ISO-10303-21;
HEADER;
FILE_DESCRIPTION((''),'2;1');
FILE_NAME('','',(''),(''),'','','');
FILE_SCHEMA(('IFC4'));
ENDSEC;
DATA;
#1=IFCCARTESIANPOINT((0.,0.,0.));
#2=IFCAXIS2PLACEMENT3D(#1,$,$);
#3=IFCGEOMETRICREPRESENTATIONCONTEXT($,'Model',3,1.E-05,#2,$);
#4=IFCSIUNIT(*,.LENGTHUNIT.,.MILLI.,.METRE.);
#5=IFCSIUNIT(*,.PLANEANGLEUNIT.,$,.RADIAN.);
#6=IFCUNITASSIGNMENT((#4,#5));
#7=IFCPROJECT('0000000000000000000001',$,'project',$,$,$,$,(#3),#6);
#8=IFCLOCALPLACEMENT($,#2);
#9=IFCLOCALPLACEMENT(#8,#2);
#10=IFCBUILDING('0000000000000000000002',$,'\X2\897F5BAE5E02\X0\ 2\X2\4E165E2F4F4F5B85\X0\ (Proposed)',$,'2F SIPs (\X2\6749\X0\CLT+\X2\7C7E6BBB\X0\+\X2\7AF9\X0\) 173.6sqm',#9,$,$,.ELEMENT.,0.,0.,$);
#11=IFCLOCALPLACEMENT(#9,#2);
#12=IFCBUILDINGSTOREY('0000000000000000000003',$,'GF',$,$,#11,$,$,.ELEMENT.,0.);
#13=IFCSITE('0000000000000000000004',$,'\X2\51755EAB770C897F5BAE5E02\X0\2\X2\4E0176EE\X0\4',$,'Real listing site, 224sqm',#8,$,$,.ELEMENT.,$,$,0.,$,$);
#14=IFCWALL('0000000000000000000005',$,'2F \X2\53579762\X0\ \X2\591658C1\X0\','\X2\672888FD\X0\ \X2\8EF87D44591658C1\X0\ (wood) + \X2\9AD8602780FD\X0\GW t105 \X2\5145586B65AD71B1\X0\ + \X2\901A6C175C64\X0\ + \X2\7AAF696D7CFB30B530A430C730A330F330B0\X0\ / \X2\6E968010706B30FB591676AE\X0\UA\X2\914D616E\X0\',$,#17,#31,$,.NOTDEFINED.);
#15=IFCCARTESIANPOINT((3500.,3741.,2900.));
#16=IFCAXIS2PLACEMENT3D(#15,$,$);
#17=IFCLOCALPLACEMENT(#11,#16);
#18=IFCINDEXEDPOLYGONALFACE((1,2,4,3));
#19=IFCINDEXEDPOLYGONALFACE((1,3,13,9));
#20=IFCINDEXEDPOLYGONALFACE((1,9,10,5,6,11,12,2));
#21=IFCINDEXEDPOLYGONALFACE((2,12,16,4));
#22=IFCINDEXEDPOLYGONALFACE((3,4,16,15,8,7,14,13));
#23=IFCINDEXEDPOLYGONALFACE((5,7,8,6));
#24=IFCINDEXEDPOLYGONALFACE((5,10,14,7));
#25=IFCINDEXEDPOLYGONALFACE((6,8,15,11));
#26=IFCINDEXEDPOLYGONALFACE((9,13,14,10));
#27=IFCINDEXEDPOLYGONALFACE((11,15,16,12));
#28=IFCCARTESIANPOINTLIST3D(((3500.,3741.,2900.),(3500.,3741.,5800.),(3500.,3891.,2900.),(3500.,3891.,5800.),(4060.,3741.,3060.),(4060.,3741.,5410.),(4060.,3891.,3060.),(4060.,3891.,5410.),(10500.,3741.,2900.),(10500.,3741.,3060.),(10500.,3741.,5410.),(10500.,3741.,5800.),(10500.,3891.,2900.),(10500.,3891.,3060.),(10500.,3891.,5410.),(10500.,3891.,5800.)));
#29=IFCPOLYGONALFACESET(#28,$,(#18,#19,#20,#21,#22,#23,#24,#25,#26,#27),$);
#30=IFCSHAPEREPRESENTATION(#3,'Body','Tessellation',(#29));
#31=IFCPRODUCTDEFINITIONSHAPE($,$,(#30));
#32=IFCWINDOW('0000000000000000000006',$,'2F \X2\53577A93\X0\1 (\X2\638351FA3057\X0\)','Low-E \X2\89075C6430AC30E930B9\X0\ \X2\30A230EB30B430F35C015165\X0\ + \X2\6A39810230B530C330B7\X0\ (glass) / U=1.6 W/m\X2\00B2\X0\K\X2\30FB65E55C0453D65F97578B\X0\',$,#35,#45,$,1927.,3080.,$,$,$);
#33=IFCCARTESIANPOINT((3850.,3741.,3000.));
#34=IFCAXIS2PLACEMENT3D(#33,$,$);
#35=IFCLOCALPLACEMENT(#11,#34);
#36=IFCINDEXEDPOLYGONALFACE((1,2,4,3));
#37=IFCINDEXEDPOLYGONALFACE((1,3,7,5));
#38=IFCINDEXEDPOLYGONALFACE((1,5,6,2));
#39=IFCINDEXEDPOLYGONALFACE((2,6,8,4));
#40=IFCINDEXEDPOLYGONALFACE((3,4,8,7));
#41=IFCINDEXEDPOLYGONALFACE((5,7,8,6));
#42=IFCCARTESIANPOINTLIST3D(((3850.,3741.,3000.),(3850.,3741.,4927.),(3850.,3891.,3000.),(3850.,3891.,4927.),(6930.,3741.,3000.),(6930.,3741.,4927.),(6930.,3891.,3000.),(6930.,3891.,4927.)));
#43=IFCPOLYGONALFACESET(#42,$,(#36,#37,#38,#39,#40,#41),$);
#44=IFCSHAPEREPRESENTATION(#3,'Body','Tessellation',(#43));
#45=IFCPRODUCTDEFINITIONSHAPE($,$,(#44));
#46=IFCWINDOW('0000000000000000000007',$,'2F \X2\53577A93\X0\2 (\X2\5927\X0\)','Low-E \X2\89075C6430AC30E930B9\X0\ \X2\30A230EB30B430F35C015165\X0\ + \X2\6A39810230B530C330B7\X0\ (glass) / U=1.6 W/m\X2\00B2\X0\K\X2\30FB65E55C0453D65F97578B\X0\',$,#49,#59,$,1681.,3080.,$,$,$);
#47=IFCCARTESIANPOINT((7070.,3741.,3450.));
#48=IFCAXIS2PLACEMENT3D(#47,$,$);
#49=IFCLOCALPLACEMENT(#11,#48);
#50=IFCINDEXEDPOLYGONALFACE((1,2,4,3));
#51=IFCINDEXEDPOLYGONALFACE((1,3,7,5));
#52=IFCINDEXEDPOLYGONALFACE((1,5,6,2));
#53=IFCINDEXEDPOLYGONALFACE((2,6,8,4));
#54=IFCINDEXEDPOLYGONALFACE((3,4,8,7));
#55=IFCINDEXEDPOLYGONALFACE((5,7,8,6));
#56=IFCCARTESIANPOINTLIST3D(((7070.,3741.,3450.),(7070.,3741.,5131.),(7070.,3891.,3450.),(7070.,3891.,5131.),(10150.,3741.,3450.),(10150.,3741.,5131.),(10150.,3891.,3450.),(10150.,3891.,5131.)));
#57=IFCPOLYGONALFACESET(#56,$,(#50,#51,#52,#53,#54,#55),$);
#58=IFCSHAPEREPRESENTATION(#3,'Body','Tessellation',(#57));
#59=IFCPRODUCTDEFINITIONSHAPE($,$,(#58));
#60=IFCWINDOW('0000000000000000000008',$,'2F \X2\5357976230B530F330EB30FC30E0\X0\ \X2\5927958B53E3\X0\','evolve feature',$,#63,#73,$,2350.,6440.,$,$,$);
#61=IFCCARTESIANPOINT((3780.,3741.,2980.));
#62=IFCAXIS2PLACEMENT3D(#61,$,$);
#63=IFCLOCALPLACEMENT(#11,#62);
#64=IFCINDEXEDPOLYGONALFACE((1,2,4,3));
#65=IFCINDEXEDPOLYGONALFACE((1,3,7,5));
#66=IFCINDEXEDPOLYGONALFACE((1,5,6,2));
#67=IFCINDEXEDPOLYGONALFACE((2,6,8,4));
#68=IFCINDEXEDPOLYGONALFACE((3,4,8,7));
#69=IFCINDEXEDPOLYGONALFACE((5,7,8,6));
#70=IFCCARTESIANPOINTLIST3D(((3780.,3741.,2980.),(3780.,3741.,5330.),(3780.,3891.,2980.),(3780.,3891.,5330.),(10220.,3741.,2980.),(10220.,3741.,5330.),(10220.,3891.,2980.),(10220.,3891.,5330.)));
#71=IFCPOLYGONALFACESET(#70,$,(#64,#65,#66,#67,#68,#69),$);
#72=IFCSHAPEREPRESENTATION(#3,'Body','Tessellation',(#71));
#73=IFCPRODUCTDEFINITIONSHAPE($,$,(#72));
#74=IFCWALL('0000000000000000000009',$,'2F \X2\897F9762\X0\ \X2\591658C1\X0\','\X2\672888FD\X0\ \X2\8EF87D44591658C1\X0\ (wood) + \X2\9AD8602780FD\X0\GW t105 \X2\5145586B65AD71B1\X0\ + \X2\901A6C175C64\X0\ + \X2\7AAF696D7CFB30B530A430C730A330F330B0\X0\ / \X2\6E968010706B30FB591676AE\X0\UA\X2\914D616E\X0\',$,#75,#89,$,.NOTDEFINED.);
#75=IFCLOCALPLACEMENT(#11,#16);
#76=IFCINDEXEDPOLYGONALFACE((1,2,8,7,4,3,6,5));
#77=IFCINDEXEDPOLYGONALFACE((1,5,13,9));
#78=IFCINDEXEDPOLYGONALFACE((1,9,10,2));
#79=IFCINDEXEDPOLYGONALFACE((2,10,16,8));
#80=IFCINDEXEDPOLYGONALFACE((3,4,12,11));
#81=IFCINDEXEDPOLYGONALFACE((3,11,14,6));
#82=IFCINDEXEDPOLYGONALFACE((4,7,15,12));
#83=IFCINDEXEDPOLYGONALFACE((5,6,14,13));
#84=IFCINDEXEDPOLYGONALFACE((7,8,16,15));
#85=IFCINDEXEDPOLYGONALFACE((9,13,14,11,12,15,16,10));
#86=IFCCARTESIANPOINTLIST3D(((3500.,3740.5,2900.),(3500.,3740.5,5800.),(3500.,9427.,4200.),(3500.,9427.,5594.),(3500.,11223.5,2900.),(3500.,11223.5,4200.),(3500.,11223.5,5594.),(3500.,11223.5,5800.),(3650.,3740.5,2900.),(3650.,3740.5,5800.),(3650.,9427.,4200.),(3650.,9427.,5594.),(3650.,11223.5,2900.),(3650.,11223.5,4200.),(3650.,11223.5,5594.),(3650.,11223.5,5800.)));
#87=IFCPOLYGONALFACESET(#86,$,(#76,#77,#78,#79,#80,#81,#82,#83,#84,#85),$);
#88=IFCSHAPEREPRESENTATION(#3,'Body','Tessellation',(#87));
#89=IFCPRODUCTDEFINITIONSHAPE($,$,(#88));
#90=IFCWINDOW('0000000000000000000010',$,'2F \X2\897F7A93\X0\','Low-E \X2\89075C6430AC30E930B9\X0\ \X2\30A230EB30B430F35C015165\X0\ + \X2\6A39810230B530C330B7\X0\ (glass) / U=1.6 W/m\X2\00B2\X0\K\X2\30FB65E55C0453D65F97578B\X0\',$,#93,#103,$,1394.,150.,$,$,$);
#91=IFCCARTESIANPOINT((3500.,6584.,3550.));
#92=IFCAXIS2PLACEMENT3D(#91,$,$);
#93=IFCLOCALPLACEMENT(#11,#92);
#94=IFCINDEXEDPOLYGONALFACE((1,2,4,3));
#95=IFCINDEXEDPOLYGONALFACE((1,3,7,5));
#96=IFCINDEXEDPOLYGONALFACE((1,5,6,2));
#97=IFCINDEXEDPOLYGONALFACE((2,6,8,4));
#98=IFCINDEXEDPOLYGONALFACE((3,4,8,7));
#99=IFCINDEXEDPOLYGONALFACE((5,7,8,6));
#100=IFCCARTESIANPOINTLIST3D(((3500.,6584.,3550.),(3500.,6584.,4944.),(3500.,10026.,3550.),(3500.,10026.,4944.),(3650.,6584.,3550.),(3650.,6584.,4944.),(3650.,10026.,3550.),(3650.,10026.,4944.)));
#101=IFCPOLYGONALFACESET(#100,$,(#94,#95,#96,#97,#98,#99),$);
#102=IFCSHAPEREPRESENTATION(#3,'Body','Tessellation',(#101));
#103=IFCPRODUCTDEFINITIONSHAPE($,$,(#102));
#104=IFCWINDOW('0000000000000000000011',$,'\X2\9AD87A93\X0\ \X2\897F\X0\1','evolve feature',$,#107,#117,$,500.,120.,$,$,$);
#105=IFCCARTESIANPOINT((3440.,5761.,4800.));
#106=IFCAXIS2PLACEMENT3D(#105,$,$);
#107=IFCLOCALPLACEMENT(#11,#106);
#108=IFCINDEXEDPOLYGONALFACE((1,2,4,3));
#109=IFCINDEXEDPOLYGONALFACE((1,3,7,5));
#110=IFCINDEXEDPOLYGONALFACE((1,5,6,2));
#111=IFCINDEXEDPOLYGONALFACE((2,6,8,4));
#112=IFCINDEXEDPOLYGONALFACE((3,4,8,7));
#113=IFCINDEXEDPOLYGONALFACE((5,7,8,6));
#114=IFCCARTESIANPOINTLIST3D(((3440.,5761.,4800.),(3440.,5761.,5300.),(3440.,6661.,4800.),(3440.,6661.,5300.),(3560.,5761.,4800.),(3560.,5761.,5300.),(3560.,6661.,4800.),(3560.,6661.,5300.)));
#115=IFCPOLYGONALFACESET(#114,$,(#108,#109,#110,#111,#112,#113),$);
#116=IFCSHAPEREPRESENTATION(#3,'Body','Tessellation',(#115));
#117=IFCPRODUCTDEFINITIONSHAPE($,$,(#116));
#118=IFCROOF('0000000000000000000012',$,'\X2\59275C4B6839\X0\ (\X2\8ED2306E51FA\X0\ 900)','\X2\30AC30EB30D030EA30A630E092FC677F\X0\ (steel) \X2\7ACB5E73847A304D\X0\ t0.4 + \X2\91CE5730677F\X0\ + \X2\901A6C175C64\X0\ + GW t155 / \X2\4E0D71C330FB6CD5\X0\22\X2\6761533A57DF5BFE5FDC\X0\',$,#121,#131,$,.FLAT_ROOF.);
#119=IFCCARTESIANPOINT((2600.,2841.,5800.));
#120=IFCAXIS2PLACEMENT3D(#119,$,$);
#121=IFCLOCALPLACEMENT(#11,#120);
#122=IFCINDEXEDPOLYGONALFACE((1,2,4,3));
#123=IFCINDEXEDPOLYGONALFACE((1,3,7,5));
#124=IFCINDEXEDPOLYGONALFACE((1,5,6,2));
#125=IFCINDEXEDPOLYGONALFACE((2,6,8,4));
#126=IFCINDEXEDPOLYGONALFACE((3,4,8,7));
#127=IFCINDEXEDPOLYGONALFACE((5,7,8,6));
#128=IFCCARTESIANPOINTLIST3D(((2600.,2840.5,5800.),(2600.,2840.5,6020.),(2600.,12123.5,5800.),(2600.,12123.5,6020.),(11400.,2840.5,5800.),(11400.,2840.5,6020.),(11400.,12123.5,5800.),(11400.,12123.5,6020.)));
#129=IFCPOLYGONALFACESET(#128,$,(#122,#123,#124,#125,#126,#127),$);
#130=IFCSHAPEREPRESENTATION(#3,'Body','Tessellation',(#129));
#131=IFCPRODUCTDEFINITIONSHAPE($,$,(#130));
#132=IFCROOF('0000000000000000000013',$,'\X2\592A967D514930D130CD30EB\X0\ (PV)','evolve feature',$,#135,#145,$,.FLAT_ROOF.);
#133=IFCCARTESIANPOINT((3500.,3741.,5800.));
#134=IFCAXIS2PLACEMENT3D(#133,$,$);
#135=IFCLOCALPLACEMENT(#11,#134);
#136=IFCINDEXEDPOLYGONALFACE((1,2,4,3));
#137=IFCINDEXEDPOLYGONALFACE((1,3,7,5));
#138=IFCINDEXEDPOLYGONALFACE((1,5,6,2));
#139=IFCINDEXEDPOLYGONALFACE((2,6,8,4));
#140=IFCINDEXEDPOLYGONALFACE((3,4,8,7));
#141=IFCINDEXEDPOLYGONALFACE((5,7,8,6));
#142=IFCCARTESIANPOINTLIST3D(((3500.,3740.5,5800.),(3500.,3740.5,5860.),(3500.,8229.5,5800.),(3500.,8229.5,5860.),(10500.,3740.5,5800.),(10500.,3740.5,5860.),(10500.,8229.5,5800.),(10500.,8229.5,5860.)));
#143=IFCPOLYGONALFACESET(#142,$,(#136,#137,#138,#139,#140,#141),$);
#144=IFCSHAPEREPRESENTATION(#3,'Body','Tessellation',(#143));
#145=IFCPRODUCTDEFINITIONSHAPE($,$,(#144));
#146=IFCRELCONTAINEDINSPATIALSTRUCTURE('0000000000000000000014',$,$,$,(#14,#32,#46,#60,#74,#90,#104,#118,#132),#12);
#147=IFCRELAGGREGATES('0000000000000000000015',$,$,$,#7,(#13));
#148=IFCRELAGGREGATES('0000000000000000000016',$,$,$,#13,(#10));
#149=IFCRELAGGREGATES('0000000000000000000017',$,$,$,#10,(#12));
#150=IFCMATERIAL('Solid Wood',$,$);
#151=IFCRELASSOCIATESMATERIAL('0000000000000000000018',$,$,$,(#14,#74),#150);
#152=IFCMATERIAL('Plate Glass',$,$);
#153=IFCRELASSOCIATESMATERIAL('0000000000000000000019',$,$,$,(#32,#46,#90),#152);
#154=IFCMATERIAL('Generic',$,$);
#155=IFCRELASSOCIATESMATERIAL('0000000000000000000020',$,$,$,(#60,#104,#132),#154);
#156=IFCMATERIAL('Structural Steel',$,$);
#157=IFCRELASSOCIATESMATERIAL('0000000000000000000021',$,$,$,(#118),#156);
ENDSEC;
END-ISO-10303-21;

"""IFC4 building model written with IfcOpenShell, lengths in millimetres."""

from ifc_helpers import new_model, si_unit, frame, frame_2d, origin, place, context, project, spatial, rectangle, extrude, material, element, fill, save


model = new_model("IFC4")

# Units and contexts
model_context = context("Model", 3, precision=1e-05, world=origin())
ifc_project = project(units=[si_unit("LENGTHUNIT", "METRE", prefix="MILLI"), si_unit("PLANEANGLEUNIT", "RADIAN")], contexts=[model_context])

# Site, building, storey
site_placement = place(None, origin())
site = spatial("IfcSite", under=ifc_project, at=site_placement, Name="兵庫県西宮市2丁目4", ObjectType="Real listing site, 224sqm", CompositionType="ELEMENT", RefElevation=0.0)
building_placement = place(site_placement, origin())
building = spatial("IfcBuilding", under=site, at=building_placement, Name="西宮市 2世帯住宅 (Proposed)", ObjectType="2F SIPs (杉CLT+籾殻+竹) 173.6sqm", CompositionType="ELEMENT", ElevationOfRefHeight=0.0, ElevationOfTerrain=0.0)
storey_placement = place(building_placement, origin())
storey = spatial("IfcBuildingStorey", under=building, at=storey_placement, Name="GF", CompositionType="ELEMENT", Elevation=0.0)

# Shared definitions
ifc_material_1 = material(Name="Solid Wood")
ifc_material_2 = material(Name="Generic")

# Shared definitions
ifc_material_3 = material(Name="Plate Glass")

# Walls, openings, windows
wall_1_placement = place(storey_placement, frame((3500.0, 3741.0, 2900.0)))
wall_1 = element("IfcWall", 1, at=wall_1_placement, inside=storey, material=ifc_material_1, Name="2F 南面 外壁", Description="木製 軸組外壁 (wood) + 高性能GW t105 充填断熱 + 通気層 + 窯業系サイディング / 準耐火・外皮UA配慮", PredefinedType="NOTDEFINED", context=model_context, shape_type="SweptSolid", body=[
    extrude(rectangle(XDim=7000.0, YDim=150.0, at=frame_2d((3500.0, 75.0))), frame((3500.0, 3741.0, 2900.0)), (0.0, 0.0, 1.0), 2900.0),
])
opening_1_placement = place(storey_placement, frame((3850.0, 3741.0, 3000.0)))
opening_1 = element("IfcOpeningElement", 2, at=opening_1_placement, cuts=wall_1, PredefinedType="NOTDEFINED", context=model_context, shape_type="SweptSolid", body=[
    extrude(rectangle(XDim=3080.0, YDim=150.0, at=frame_2d((1540.0, 75.0))), frame((3850.0, 3741.0, 3000.0)), (0.0, 0.0, 1.0), 1927.0),
])
opening_2_placement = place(storey_placement, frame((7070.0, 3741.0, 3450.0)))
opening_2 = element("IfcOpeningElement", 3, at=opening_2_placement, cuts=wall_1, PredefinedType="NOTDEFINED", context=model_context, shape_type="SweptSolid", body=[
    extrude(rectangle(XDim=3080.0, YDim=150.0, at=frame_2d((1540.0, 75.0))), frame((7070.0, 3741.0, 3450.0)), (0.0, 0.0, 1.0), 1681.0),
])
opening_3_placement = place(storey_placement, frame((3780.0, 3741.0, 2980.0)))
opening_3 = element("IfcOpeningElement", 4, at=opening_3_placement, cuts=wall_1, PredefinedType="NOTDEFINED", context=model_context, shape_type="SweptSolid", body=[
    extrude(rectangle(XDim=6440.0, YDim=150.0, at=frame_2d((3220.0, 75.0))), frame((3780.0, 3741.0, 2980.0)), (0.0, 0.0, 1.0), 2350.0),
])
window_1_placement = place(storey_placement, frame((3850.0, 3741.0, 3000.0)))
window_1 = element("IfcWindow", 5, at=window_1_placement, inside=storey, material=ifc_material_3, Name="2F 南窓1 (掃出し)", Description="Low-E 複層ガラス アルゴン封入 + 樹脂サッシ (glass) / U=1.6 W/m²K・日射取得型", OverallHeight=1927.0, OverallWidth=3080.0, context=model_context, shape_type="SweptSolid", body=[
    extrude(rectangle(XDim=3080.0, YDim=150.0, at=frame_2d((1540.0, 75.0))), frame((3850.0, 3741.0, 3000.0)), (0.0, 0.0, 1.0), 1927.0),
])
fill(opening_1, window_1)
window_2_placement = place(storey_placement, frame((7070.0, 3741.0, 3450.0)))
window_2 = element("IfcWindow", 6, at=window_2_placement, inside=storey, material=ifc_material_3, Name="2F 南窓2 (大)", Description="Low-E 複層ガラス アルゴン封入 + 樹脂サッシ (glass) / U=1.6 W/m²K・日射取得型", OverallHeight=1681.0, OverallWidth=3080.0, context=model_context, shape_type="SweptSolid", body=[
    extrude(rectangle(XDim=3080.0, YDim=150.0, at=frame_2d((1540.0, 75.0))), frame((7070.0, 3741.0, 3450.0)), (0.0, 0.0, 1.0), 1681.0),
])
fill(opening_2, window_2)
window_3_placement = place(storey_placement, frame((3780.0, 3741.0, 2980.0)))
window_3 = element("IfcWindow", 7, at=window_3_placement, inside=storey, material=ifc_material_2, Name="2F 南面サンルーム 大開口", Description="evolve feature", OverallHeight=2350.0, OverallWidth=6440.0, context=model_context, shape_type="SweptSolid", body=[
    extrude(rectangle(XDim=6440.0, YDim=150.0, at=frame_2d((3220.0, 75.0))), frame((3780.0, 3741.0, 2980.0)), (0.0, 0.0, 1.0), 2350.0),
])
fill(opening_3, window_3)
wall_2_placement = place(storey_placement, frame((3500.0, 3741.0, 2900.0)))
wall_2 = element("IfcWall", 8, at=wall_2_placement, inside=storey, material=ifc_material_1, Name="2F 西面 外壁", Description="木製 軸組外壁 (wood) + 高性能GW t105 充填断熱 + 通気層 + 窯業系サイディング / 準耐火・外皮UA配慮", PredefinedType="NOTDEFINED", context=model_context, shape_type="SweptSolid", body=[
    extrude(rectangle(XDim=150.0, YDim=7483.0, at=frame_2d((75.0, 3741.0))), frame((3500.0, 3741.0, 2900.0)), (0.0, 0.0, 1.0), 2900.0),
])
opening_4_placement = place(storey_placement, frame((3500.0, 6584.0, 3550.0)))
opening_4 = element("IfcOpeningElement", 9, at=opening_4_placement, cuts=wall_2, PredefinedType="NOTDEFINED", context=model_context, shape_type="SweptSolid", body=[
    extrude(rectangle(XDim=150.0, YDim=3442.0, at=frame_2d((75.0, 1721.0))), frame((3500.0, 6584.0, 3550.0)), (0.0, 0.0, 1.0), 1394.0),
])
opening_5_placement = place(storey_placement, frame((3440.0, 5761.0, 4800.0)))
opening_5 = element("IfcOpeningElement", 10, at=opening_5_placement, cuts=wall_2, PredefinedType="NOTDEFINED", context=model_context, shape_type="SweptSolid", body=[
    extrude(rectangle(XDim=120.0, YDim=900.0, at=frame_2d((60.0, 450.0))), frame((3440.0, 5761.0, 4800.0)), (0.0, 0.0, 1.0), 500.0),
])
window_4_placement = place(storey_placement, frame((3500.0, 6584.0, 3550.0)))
window_4 = element("IfcWindow", 11, at=window_4_placement, inside=storey, material=ifc_material_3, Name="2F 西窓", Description="Low-E 複層ガラス アルゴン封入 + 樹脂サッシ (glass) / U=1.6 W/m²K・日射取得型", OverallHeight=1394.0, OverallWidth=150.0, context=model_context, shape_type="SweptSolid", body=[
    extrude(rectangle(XDim=150.0, YDim=3442.0, at=frame_2d((75.0, 1721.0))), frame((3500.0, 6584.0, 3550.0)), (0.0, 0.0, 1.0), 1394.0),
])
fill(opening_4, window_4)
window_5_placement = place(storey_placement, frame((3440.0, 5761.0, 4800.0)))
window_5 = element("IfcWindow", 12, at=window_5_placement, inside=storey, material=ifc_material_2, Name="高窓 西1", Description="evolve feature", OverallHeight=500.0, OverallWidth=120.0, context=model_context, shape_type="SweptSolid", body=[
    extrude(rectangle(XDim=120.0, YDim=900.0, at=frame_2d((60.0, 450.0))), frame((3440.0, 5761.0, 4800.0)), (0.0, 0.0, 1.0), 500.0),
])
fill(opening_5, window_5)

# Roofs
ifc_material_4 = material(Name="Structural Steel")
roof_1_placement = place(storey_placement, frame((2600.0, 2841.0, 5800.0)))
element("IfcRoof", 13, at=roof_1_placement, inside=storey, material=ifc_material_4, Name="大屋根 (軒の出 900)", Description="ガルバリウム鋼板 (steel) 立平葺き t0.4 + 野地板 + 通気層 + GW t155 / 不燃・法22条区域対応", PredefinedType="FLAT_ROOF", context=model_context, shape_type="SweptSolid", body=[
    extrude(rectangle(XDim=8800.0, YDim=9283.0, at=frame_2d((4400.0, 4641.0))), frame((2600.0, 2841.0, 5800.0)), (0.0, 0.0, 1.0), 220.0),
])
roof_2_placement = place(storey_placement, frame((3500.0, 3741.0, 5800.0)))
element("IfcRoof", 14, at=roof_2_placement, inside=storey, material=ifc_material_2, Name="太陽光パネル (PV)", Description="evolve feature", PredefinedType="FLAT_ROOF", context=model_context, shape_type="SweptSolid", body=[
    extrude(rectangle(XDim=7000.0, YDim=4489.0, at=frame_2d((3500.0, 2244.0))), frame((3500.0, 3741.0, 5800.0)), (0.0, 0.0, 1.0), 60.0),
])

save(model, "model.ifc")
